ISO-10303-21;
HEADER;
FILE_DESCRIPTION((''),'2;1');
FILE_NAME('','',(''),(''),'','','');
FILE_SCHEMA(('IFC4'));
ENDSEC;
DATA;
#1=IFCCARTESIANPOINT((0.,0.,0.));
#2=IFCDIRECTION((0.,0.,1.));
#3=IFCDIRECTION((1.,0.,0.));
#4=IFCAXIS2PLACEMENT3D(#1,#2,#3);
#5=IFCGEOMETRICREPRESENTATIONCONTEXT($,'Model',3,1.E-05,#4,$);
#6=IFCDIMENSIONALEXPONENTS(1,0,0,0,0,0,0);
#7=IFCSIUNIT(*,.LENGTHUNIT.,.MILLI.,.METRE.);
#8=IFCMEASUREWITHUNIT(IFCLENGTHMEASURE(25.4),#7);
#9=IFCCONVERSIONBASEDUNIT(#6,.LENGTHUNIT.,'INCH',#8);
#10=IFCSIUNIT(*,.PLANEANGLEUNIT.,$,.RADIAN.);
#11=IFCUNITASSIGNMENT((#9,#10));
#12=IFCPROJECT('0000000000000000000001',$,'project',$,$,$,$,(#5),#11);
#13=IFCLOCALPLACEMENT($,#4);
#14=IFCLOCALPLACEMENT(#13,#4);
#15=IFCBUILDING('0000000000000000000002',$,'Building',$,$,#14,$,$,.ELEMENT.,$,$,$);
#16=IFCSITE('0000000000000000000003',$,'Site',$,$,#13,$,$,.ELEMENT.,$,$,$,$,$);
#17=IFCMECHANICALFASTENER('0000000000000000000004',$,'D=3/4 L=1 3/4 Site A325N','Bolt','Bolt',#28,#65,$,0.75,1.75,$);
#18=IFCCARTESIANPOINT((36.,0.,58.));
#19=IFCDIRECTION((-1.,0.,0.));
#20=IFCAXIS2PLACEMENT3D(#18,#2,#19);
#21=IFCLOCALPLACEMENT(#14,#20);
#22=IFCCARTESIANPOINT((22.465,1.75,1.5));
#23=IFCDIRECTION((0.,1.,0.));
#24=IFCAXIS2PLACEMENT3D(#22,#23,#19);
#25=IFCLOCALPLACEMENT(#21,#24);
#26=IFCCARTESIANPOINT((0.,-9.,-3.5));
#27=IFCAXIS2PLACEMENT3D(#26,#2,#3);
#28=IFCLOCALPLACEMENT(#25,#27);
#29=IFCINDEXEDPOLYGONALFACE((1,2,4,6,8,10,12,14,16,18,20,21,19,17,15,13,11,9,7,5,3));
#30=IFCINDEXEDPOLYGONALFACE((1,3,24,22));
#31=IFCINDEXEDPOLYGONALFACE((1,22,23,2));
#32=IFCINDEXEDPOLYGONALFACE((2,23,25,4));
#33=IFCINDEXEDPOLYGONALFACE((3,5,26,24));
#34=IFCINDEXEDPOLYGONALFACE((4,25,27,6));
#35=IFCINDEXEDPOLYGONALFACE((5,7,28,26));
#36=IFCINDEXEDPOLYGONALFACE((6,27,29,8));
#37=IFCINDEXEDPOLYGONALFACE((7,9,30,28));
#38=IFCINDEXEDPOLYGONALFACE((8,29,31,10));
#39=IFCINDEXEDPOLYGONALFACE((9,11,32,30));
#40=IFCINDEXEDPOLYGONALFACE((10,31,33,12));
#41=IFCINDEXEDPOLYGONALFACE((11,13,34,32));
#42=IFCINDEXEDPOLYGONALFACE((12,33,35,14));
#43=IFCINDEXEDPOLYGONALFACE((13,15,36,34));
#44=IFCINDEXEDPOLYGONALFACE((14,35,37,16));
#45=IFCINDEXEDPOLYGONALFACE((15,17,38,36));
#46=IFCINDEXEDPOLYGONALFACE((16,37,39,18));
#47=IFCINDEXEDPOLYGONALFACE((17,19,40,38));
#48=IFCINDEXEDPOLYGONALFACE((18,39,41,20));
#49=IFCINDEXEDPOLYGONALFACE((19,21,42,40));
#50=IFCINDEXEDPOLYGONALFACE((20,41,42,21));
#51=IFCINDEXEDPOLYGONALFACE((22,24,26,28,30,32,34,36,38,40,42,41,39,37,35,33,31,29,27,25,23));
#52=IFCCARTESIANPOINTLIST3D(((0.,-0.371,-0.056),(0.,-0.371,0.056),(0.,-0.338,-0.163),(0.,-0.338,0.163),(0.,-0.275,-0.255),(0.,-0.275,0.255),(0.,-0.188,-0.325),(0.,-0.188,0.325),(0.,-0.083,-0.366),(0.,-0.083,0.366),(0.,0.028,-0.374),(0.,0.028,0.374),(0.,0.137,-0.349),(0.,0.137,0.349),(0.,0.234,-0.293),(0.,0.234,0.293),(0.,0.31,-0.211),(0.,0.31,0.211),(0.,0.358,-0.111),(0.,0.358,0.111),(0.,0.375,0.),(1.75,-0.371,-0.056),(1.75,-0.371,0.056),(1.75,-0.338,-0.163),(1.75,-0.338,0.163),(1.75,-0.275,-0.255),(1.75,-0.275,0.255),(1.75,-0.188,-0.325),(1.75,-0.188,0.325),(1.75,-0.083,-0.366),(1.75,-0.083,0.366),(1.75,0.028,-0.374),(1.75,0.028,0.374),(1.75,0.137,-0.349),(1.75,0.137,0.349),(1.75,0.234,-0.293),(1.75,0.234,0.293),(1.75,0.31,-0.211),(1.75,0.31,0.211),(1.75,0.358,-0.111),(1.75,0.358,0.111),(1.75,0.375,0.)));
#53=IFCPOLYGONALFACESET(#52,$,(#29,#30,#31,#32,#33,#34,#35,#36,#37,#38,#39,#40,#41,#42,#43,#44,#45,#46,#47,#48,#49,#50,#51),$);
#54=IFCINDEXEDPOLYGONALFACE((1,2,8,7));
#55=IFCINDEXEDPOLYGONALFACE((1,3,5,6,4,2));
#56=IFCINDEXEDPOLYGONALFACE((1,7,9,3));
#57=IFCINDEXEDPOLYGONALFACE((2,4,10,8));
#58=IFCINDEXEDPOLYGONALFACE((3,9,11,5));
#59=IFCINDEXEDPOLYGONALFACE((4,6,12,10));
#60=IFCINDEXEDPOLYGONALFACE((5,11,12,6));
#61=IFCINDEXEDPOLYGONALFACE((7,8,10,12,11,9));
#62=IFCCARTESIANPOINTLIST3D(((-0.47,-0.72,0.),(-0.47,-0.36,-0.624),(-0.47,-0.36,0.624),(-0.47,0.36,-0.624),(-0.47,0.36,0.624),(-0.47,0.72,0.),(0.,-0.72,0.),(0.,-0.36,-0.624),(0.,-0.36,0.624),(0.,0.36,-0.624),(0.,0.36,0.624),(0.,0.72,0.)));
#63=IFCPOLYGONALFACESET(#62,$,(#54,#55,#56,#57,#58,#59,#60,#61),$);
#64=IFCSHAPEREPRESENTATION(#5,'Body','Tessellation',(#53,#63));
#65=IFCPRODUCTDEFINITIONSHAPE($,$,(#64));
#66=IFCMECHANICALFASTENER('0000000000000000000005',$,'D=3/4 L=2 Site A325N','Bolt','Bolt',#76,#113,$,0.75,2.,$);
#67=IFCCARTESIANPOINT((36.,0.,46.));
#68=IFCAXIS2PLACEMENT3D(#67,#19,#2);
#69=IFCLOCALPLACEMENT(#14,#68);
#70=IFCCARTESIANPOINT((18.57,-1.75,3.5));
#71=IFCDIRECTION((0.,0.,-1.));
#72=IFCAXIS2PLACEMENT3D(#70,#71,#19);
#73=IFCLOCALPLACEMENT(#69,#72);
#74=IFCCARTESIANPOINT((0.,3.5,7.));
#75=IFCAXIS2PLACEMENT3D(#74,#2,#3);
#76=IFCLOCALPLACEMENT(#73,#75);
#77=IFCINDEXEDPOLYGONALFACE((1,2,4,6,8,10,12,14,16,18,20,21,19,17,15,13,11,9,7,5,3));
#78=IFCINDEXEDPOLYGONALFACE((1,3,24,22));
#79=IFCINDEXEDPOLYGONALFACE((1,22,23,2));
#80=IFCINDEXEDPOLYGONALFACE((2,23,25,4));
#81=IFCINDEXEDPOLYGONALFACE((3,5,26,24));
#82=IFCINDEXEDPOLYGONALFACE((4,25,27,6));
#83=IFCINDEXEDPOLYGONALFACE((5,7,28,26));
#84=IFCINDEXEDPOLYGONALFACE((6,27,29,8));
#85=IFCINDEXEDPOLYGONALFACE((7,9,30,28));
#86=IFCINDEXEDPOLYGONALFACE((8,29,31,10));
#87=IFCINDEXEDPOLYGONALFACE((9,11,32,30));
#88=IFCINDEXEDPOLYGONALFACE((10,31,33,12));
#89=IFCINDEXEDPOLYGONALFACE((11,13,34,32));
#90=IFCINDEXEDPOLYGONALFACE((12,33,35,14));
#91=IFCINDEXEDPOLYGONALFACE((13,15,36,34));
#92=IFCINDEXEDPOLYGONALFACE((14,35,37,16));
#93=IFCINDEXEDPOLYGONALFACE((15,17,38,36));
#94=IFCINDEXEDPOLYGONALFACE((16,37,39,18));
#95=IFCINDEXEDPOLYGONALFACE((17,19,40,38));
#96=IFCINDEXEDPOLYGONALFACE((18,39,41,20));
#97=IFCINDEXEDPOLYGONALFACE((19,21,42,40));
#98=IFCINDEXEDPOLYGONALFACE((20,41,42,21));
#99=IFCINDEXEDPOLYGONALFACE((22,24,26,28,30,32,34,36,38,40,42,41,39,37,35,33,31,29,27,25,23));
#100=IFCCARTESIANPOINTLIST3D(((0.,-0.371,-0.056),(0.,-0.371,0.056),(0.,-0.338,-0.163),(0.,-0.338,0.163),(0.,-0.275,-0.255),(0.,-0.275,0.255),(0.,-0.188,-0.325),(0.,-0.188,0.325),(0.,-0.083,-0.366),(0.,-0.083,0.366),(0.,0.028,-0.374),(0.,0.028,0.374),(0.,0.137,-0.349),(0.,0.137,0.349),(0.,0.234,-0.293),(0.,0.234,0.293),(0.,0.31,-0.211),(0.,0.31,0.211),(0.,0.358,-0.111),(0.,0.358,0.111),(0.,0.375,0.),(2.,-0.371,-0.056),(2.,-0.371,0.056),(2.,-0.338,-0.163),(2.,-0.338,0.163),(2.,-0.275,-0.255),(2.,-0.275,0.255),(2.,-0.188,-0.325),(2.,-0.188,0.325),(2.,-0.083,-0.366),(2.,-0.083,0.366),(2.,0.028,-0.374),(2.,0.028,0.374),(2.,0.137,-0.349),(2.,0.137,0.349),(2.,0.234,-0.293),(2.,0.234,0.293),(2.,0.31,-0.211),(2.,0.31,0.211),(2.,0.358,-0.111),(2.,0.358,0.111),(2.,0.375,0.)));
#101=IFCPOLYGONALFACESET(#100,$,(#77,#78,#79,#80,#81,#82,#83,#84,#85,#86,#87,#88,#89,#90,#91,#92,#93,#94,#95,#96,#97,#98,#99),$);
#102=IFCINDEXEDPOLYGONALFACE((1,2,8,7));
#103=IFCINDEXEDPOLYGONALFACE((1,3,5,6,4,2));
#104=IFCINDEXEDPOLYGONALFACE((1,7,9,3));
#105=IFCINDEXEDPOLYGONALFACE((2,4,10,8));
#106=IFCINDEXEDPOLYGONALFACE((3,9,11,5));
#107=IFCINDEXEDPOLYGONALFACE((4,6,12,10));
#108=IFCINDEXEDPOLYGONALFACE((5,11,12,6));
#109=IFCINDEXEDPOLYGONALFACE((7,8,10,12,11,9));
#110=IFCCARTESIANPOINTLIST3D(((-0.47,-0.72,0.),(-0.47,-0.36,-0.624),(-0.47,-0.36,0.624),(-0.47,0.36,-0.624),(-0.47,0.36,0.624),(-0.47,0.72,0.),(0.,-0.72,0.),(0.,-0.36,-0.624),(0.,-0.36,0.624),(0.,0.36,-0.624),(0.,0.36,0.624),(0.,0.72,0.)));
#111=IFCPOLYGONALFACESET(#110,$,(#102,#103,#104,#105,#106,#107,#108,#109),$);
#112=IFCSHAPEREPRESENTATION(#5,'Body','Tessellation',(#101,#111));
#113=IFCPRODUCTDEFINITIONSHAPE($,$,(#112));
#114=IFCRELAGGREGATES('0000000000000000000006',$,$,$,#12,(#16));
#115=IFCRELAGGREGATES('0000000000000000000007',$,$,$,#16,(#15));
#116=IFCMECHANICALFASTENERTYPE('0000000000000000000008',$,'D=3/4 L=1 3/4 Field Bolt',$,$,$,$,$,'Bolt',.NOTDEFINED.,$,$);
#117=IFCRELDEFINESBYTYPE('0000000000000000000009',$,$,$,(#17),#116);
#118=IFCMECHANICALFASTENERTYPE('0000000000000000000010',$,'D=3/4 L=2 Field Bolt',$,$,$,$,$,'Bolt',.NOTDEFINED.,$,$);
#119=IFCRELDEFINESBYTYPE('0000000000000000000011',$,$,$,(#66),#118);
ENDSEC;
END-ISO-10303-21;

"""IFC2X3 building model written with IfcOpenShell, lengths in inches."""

from ifc_helpers import new_model, entity, si_unit, converted_unit, frame, origin_with_axes, origin_2d_with_axis, place, context, project, spatial, polyline, circle, outline, extrude, source, transform, mapped, type_object, type_shapes, element, save


model = new_model("IFC2X3")

# Units and contexts
model_context = context("Model", 3, precision=1e-05, world=origin_with_axes())
ifc_project = project(units=[converted_unit("LENGTHUNIT", "INCH", entity("IfcLengthMeasure", 25.4), si_unit("LENGTHUNIT", "METRE", prefix="MILLI"), dimensions=[1, 0, 0, 0, 0, 0, 0]), si_unit("PLANEANGLEUNIT", "RADIAN")], contexts=[model_context])

# Site, building
site_placement = place(None, origin_with_axes())
site = spatial("IfcSite", under=ifc_project, at=site_placement, Name="Site", CompositionType="ELEMENT")
building_placement = place(site_placement, origin_with_axes())
building = spatial("IfcBuilding", under=site, at=building_placement, Name="Building", CompositionType="ELEMENT")

# Mechanical fasteners
mechanical_fastener_type_1 = type_object("IfcMechanicalFastenerType", Name="D=3/4 L=1 3/4 Field Bolt", ElementType="Bolt")
shared_shape_1 = source(origin_with_axes(), model_context, "Body", "SweptSolid", [
    extrude(circle(Radius=0.375, at=origin_2d_with_axis()), frame((0.0, 0.0, 0.0), z_axis=(1.0, 0.0, 0.0), x_axis=(0.0, 1.0, 0.0)), (0.0, 0.0, 1.0), 1.75),
    extrude(outline(polyline([(-0.72, 0.0), (-0.36, 0.624), (0.36, 0.624), (0.72, 0.0), (0.36, -0.624), (-0.36, -0.624), (-0.72, 0.0)])), frame((0.0, 0.0, 0.0), z_axis=(1.0, 0.0, 0.0), x_axis=(0.0, 1.0, 0.0)), (0.0, 0.0, -1.0), 0.47),
])
type_shapes(mechanical_fastener_type_1, [shared_shape_1])
placement_1 = place(building_placement, frame((36.0, 0.0, 58.0), z_axis=(0.0, 0.0, 1.0), x_axis=(-1.0, 0.0, 0.0)))
placement_2 = place(placement_1, frame((22.465, 1.75, 1.5), z_axis=(0.0, 1.0, 0.0), x_axis=(-1.0, 0.0, 0.0)))
for number, where, z_axis, x_axis, name in (
    (1, (0.0, -9.0, -3.5), (0.0, 0.0, 1.0), (1.0, 0.0, 0.0), "D=3/4 L=1 3/4 Site A325N"),
):
    element("IfcMechanicalFastener", number, at=place(placement_2, frame(where, z_axis=z_axis, x_axis=x_axis)), type_object=mechanical_fastener_type_1, Name=name, Description="Bolt", ObjectType="Bolt", NominalDiameter=0.75, NominalLength=1.75, context=model_context, shape_type="MappedRepresentation", body=[
        mapped(shared_shape_1, transform((0.0, 0.0, 0.0), scale=1.0)),
    ])
mechanical_fastener_type_2 = type_object("IfcMechanicalFastenerType", Name="D=3/4 L=2 Field Bolt", ElementType="Bolt")
shared_shape_2 = source(origin_with_axes(), model_context, "Body", "SweptSolid", [
    extrude(circle(Radius=0.375, at=origin_2d_with_axis()), frame((0.0, 0.0, 0.0), z_axis=(1.0, 0.0, 0.0), x_axis=(0.0, 1.0, 0.0)), (0.0, 0.0, 1.0), 2.0),
    extrude(outline(polyline([(-0.72, 0.0), (-0.36, 0.624), (0.36, 0.624), (0.72, 0.0), (0.36, -0.624), (-0.36, -0.624), (-0.72, 0.0)])), frame((0.0, 0.0, 0.0), z_axis=(1.0, 0.0, 0.0), x_axis=(0.0, 1.0, 0.0)), (0.0, 0.0, -1.0), 0.47),
])
type_shapes(mechanical_fastener_type_2, [shared_shape_2])
placement_3 = place(building_placement, frame((36.0, 0.0, 46.0), z_axis=(-1.0, 0.0, 0.0), x_axis=(0.0, 0.0, 1.0)))
placement_4 = place(placement_3, frame((18.57, -1.75, 3.5), z_axis=(0.0, 0.0, -1.0), x_axis=(-1.0, 0.0, 0.0)))
for number, where, z_axis, x_axis, name in (
    (2, (0.0, 3.5, 7.0), (0.0, 0.0, 1.0), (1.0, 0.0, 0.0), "D=3/4 L=2 Site A325N"),
):
    element("IfcMechanicalFastener", number, at=place(placement_4, frame(where, z_axis=z_axis, x_axis=x_axis)), type_object=mechanical_fastener_type_2, Name=name, Description="Bolt", ObjectType="Bolt", NominalDiameter=0.75, NominalLength=2.0, context=model_context, shape_type="MappedRepresentation", body=[
        mapped(shared_shape_2, transform((0.0, 0.0, 0.0), scale=1.0)),
    ])

save(model, "model.ifc")
